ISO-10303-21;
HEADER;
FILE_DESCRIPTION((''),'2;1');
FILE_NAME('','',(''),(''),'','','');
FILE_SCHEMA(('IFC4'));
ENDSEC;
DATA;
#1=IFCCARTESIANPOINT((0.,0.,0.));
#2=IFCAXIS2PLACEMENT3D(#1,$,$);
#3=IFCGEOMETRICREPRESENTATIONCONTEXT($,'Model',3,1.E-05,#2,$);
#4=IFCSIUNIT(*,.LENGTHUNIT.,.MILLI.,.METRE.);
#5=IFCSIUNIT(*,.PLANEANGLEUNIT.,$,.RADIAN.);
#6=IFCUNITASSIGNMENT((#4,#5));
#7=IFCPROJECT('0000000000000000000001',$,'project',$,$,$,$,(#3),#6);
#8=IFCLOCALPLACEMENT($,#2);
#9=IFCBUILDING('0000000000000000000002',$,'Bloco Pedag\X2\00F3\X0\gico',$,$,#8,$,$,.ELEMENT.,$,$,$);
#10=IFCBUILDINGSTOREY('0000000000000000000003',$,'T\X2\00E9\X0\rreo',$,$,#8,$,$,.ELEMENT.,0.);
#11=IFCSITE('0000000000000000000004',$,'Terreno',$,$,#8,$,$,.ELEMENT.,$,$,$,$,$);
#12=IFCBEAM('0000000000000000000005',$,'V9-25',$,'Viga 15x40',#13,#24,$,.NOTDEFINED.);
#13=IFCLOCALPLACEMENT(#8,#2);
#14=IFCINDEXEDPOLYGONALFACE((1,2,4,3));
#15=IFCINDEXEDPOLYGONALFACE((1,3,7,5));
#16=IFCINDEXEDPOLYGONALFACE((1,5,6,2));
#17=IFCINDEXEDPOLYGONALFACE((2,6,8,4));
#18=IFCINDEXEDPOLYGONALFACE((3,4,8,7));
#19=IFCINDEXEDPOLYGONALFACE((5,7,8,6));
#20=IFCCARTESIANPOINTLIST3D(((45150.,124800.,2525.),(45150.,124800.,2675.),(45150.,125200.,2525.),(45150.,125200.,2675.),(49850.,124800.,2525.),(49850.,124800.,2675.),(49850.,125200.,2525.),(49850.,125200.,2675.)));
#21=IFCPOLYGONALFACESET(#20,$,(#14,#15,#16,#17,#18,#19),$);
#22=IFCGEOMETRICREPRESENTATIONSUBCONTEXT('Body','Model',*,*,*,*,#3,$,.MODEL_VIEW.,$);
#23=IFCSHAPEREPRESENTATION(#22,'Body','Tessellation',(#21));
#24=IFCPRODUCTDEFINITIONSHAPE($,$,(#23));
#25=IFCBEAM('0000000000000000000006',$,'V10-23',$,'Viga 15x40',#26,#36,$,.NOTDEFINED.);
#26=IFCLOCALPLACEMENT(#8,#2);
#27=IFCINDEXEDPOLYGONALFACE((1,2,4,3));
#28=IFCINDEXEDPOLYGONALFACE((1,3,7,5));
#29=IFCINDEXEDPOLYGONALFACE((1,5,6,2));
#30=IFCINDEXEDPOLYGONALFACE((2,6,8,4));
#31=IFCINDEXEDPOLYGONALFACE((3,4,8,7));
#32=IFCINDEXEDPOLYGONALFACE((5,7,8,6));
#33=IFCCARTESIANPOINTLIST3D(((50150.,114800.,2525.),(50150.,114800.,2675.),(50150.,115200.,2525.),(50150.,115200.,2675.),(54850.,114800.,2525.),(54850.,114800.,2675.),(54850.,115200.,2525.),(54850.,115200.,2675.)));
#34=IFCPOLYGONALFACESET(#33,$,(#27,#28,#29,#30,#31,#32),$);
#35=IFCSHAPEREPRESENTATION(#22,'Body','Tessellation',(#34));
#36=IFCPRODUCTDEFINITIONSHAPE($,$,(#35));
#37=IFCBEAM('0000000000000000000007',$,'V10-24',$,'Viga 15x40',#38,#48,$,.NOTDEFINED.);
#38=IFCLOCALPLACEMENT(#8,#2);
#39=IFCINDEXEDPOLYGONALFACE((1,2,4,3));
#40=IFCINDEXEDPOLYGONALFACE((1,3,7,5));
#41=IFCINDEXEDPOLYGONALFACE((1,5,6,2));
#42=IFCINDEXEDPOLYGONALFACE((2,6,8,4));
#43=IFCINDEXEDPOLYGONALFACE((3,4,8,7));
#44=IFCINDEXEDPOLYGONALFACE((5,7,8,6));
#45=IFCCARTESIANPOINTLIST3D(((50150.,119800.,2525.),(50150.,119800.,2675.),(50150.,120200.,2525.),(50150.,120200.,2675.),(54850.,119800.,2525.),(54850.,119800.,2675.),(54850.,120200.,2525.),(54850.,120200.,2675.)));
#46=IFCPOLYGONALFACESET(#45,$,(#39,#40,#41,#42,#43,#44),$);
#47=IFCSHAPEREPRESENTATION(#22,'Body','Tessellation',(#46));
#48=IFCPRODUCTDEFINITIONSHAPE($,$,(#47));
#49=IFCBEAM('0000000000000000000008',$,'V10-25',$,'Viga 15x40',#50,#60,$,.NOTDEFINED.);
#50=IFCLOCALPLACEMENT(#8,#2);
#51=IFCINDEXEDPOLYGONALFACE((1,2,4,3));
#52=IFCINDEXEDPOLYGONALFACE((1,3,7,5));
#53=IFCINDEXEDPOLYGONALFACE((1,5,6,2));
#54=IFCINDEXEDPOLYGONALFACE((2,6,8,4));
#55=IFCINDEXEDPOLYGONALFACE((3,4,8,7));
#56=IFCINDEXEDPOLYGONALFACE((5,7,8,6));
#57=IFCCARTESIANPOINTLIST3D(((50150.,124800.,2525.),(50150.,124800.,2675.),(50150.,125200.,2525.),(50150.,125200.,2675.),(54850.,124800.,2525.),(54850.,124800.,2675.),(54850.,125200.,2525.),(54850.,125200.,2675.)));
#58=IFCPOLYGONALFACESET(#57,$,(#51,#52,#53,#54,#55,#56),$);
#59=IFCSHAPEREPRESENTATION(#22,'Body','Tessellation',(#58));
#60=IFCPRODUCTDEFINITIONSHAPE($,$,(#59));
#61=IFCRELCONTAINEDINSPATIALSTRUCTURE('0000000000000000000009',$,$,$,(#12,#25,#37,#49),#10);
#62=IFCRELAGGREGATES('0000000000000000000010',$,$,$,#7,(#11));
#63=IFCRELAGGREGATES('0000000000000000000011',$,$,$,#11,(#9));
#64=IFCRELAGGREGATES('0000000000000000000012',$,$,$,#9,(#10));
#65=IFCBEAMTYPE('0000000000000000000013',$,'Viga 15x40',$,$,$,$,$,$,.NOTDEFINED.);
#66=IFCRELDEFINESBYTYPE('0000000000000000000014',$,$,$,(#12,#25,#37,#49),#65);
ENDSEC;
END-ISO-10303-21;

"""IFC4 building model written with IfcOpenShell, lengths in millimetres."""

from ifc_helpers import new_model, si_unit, frame, origin, origin_2d, place, context, subcontext, project, spatial, rectangle, extrude, type_object, element, save


model = new_model("IFC4")

# Units and contexts
model_context = context("Model", 3, precision=1e-05, world=origin())
body_context = subcontext(model_context, "Body", "Model", "MODEL_VIEW")
ifc_project = project(units=[si_unit("LENGTHUNIT", "METRE", prefix="MILLI"), si_unit("PLANEANGLEUNIT", "RADIAN")], contexts=[model_context])

# Site, building, storey
placement = place(None, origin())
site = spatial("IfcSite", under=ifc_project, at=placement, Name="Terreno", CompositionType="ELEMENT")
building = spatial("IfcBuilding", under=site, at=placement, Name="Bloco Pedagógico", CompositionType="ELEMENT")
storey = spatial("IfcBuildingStorey", under=building, at=placement, Name="Térreo", CompositionType="ELEMENT", Elevation=0.0)

# Beams
beam_type = type_object("IfcBeamType", Name="Viga 15x40", PredefinedType="NOTDEFINED")
for number, where, z_axis, x_axis, name in (
    (1, (45150.0, 125000.0, 2600.0), (1.0, 0.0, 0.0), (0.0, 1.0, 0.0), "V9-25"),
    (2, (50150.0, 115000.0, 2600.0), (1.0, 0.0, 0.0), (0.0, 1.0, 0.0), "V10-23"),
    (3, (50150.0, 120000.0, 2600.0), (1.0, 0.0, 0.0), (0.0, 1.0, 0.0), "V10-24"),
    (4, (50150.0, 125000.0, 2600.0), (1.0, 0.0, 0.0), (0.0, 1.0, 0.0), "V10-25"),
):
    element("IfcBeam", number, at=place(None, frame(where, z_axis=z_axis, x_axis=x_axis)), inside=storey, type_object=beam_type, Name=name, ObjectType="Viga 15x40", PredefinedType="NOTDEFINED", context=body_context, shape_type="SweptSolid", body=[
        extrude(rectangle(XDim=400.0, YDim=150.0, at=origin_2d()), None, (0.0, 0.0, 1.0), 4700.0),
    ])

save(model, "model.ifc")
